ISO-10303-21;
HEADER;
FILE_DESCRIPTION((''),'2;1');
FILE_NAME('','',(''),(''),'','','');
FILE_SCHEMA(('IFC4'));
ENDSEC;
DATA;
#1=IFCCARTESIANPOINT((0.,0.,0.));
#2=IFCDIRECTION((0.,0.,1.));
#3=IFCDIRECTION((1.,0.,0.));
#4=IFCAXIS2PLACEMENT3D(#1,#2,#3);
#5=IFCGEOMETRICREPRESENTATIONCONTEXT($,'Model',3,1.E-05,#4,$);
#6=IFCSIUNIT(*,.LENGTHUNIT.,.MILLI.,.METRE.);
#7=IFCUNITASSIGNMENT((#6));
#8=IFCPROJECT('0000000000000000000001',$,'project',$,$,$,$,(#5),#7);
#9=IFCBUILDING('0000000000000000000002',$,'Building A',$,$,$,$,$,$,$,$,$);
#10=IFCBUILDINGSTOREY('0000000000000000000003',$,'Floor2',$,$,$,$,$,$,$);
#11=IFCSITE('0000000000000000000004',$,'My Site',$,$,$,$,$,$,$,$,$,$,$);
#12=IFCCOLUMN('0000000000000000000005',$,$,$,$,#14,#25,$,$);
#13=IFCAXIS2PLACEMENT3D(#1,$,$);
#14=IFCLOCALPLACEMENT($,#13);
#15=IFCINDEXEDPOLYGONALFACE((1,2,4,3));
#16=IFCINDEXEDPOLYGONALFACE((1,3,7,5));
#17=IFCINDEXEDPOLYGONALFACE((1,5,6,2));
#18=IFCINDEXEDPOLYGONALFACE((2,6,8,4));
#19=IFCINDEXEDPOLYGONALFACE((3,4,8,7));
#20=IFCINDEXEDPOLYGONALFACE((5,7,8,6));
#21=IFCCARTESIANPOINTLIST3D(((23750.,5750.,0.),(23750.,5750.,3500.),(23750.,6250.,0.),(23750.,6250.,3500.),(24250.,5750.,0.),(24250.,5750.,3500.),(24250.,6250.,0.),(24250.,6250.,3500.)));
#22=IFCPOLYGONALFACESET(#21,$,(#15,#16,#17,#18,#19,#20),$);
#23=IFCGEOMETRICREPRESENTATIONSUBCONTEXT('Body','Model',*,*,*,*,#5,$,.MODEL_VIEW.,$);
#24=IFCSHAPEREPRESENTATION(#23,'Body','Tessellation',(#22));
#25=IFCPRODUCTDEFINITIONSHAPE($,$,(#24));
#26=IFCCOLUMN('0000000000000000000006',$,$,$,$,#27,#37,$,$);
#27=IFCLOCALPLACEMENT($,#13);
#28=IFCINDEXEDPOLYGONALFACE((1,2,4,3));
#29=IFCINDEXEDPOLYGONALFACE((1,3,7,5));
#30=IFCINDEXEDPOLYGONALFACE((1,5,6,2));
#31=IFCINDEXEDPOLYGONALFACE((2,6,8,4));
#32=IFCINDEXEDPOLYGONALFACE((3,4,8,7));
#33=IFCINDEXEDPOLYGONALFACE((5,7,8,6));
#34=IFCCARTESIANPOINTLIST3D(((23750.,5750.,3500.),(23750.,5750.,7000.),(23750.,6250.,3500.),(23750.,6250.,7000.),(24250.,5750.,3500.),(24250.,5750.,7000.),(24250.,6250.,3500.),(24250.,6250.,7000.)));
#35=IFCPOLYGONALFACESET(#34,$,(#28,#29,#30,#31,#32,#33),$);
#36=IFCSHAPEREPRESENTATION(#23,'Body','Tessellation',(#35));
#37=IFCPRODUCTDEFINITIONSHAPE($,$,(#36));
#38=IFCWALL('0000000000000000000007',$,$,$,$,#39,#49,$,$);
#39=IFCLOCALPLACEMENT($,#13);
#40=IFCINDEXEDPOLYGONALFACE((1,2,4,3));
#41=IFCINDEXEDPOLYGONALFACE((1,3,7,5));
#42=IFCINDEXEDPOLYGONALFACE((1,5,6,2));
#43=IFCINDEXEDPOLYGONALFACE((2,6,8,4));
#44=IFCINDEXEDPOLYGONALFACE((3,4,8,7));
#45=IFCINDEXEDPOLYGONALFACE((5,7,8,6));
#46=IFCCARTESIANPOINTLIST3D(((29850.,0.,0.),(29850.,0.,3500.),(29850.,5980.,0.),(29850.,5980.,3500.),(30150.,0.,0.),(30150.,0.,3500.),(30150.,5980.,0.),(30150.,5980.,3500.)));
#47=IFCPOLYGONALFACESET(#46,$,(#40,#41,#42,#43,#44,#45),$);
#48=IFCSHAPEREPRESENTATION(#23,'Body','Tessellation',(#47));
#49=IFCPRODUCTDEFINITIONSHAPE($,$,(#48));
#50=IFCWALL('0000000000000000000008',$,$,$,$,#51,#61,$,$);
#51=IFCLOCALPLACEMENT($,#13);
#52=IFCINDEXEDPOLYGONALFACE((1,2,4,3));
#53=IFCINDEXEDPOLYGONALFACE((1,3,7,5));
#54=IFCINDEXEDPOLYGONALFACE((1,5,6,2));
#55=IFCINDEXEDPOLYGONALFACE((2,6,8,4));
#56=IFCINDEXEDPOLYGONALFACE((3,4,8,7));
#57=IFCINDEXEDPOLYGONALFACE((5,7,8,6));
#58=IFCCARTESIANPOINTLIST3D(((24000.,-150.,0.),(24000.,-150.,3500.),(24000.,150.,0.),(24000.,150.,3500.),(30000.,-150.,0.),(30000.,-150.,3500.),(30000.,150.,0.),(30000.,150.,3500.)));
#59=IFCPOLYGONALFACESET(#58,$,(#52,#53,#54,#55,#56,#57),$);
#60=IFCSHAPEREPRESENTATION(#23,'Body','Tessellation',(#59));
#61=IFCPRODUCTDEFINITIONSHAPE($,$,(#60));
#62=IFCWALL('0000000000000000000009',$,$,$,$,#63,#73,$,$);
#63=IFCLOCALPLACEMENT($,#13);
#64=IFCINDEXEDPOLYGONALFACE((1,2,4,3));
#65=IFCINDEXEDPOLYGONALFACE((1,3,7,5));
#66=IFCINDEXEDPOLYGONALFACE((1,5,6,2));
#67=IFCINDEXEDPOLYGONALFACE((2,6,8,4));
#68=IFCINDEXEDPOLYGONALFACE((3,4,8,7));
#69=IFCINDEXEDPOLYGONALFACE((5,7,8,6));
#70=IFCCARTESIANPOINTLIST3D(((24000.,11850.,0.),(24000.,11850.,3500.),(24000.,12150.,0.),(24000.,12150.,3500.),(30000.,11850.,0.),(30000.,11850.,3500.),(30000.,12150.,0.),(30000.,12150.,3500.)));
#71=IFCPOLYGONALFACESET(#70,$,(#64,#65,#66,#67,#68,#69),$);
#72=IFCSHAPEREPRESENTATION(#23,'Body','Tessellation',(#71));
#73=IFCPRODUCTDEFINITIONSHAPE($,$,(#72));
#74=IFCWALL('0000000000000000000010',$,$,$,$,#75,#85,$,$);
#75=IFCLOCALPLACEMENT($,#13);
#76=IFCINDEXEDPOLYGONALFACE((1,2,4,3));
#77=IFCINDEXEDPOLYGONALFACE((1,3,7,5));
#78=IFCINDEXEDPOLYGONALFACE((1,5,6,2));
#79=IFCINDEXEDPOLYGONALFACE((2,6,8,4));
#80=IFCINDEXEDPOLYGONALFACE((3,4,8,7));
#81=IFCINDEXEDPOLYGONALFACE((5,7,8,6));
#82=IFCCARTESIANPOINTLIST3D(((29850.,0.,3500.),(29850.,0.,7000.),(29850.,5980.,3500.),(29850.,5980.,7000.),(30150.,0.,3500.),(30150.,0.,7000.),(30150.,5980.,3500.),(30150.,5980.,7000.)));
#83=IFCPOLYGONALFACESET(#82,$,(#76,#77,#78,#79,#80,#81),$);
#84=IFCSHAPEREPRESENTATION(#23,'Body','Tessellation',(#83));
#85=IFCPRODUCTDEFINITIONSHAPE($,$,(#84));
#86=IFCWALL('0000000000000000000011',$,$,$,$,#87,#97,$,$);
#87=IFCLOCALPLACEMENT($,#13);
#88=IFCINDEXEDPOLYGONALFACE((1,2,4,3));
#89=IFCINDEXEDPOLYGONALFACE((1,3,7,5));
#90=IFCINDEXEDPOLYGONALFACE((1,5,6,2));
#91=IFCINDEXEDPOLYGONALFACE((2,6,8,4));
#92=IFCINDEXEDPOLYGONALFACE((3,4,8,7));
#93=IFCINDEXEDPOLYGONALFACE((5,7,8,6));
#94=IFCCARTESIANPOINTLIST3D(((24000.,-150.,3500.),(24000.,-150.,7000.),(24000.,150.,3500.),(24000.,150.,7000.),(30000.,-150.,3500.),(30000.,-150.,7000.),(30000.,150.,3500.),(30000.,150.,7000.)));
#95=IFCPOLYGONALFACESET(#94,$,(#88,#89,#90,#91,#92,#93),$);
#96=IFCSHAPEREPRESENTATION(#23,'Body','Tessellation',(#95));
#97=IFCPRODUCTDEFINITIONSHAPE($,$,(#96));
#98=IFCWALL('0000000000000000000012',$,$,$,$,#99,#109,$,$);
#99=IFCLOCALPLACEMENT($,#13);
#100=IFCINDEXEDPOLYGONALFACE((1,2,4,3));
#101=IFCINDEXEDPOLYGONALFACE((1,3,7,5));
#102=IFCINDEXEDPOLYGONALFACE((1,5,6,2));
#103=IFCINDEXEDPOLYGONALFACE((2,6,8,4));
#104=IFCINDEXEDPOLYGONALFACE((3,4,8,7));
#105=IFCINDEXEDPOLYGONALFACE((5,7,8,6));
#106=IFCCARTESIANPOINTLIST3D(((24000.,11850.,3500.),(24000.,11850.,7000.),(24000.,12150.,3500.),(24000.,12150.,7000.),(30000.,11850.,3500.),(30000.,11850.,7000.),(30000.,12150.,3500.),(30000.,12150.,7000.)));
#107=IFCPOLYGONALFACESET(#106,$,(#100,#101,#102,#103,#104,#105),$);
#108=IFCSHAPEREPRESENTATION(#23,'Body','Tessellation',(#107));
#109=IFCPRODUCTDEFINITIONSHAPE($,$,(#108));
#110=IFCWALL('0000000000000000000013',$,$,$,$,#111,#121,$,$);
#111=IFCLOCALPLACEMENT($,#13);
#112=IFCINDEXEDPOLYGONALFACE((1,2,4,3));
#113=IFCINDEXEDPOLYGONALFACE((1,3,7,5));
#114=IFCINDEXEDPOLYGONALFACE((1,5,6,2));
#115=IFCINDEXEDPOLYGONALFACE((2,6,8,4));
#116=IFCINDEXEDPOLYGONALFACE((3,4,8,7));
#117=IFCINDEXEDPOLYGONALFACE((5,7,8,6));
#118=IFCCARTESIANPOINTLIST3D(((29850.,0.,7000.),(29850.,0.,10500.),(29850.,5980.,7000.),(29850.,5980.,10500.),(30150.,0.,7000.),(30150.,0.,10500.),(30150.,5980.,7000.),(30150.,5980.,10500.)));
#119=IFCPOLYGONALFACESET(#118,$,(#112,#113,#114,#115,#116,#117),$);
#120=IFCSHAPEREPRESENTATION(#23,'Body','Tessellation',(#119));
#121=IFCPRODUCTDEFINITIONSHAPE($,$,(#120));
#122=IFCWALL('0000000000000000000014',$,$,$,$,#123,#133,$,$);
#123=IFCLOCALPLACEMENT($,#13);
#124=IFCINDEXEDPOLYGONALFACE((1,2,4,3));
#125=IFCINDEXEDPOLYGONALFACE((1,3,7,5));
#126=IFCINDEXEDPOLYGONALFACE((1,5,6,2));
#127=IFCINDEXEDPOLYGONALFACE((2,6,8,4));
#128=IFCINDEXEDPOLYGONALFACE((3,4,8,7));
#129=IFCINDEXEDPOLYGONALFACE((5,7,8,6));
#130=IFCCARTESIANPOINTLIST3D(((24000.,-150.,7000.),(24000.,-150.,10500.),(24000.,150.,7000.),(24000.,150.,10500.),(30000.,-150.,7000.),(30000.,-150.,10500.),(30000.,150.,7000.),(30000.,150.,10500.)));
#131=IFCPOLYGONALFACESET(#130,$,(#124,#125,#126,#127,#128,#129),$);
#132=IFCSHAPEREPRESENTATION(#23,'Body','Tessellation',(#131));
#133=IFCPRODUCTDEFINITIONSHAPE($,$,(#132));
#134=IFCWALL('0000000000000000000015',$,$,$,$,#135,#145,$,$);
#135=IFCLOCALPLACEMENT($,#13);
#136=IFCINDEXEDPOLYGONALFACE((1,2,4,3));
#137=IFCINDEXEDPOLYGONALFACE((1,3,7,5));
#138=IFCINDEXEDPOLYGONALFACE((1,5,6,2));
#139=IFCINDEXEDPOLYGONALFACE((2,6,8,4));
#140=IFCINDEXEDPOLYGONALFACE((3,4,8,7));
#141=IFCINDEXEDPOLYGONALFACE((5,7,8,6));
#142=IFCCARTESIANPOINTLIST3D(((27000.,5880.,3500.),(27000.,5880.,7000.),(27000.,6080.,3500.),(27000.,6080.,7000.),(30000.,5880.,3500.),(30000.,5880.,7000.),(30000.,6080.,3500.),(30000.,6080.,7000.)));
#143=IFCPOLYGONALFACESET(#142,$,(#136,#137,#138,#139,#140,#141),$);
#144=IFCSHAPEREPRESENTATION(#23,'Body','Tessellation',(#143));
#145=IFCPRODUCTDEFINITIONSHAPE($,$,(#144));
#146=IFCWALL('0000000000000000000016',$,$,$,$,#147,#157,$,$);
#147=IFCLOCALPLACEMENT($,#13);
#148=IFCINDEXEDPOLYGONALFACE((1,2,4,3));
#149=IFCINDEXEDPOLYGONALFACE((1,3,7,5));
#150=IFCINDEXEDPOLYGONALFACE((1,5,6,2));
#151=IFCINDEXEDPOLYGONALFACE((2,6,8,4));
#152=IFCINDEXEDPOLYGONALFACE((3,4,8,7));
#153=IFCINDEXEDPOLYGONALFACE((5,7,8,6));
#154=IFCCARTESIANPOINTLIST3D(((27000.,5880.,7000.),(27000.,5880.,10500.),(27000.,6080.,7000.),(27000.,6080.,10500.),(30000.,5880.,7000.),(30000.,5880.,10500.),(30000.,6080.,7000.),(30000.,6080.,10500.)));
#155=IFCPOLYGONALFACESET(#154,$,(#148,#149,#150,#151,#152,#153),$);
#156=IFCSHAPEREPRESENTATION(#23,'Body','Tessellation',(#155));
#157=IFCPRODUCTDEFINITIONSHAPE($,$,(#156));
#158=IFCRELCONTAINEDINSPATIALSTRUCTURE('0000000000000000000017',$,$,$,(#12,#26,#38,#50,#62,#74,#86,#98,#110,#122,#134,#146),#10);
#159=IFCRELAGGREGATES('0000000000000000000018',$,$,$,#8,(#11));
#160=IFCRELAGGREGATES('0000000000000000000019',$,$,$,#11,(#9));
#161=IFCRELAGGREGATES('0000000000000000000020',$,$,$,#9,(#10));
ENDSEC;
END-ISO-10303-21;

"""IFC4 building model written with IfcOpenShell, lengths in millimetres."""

from ifc_helpers import new_model, si_unit, frame, origin_with_axes, place, context, subcontext, project, spatial, line, indexed_curve, outline, extrude, element, save


model = new_model("IFC4")

# Units and contexts
model_context = context("Model", 3, precision=1e-05, world=origin_with_axes())
body_context = subcontext(model_context, "Body", "Model", "MODEL_VIEW")
ifc_project = project(units=[si_unit("LENGTHUNIT", "METRE", prefix="MILLI")], contexts=[model_context])

# Site, building, storey
site = spatial("IfcSite", under=ifc_project, Name="My Site")
building = spatial("IfcBuilding", under=site, Name="Building A")
storey = spatial("IfcBuildingStorey", under=building, Name="Floor2")

# Columns
for number, where, z_axis, x_axis in (
    (1, (24000.0, 6000.0, 0.0), (0.0, 0.0, 1.0), (1.0, 0.0, 0.0)),
    (2, (24000.0, 6000.0, 3500.0), (0.0, 0.0, 1.0), (1.0, 0.0, 0.0)),
):
    element("IfcColumn", number, at=place(None, frame(where, z_axis=z_axis, x_axis=x_axis)), inside=storey, context=body_context, shape_type="SweptSolid", body=[
        extrude(outline(indexed_curve([(-250.0, -250.0), (250.0, -250.0), (250.0, 250.0), (-250.0, 250.0)], segments=[line(1, 2, 3, 4, 1)])), origin_with_axes(), (0.0, 0.0, 1.0), 3500.0),
    ])

# Walls
wall_1_placement = place(None, frame((29850.0, 5980.0, 0.0), z_axis=(0.0, 0.0, 1.0), x_axis=(0.0, -1.0, 0.0)))
element("IfcWall", 3, at=wall_1_placement, inside=storey, context=body_context, shape_type="SweptSolid", body=[
    extrude(outline(indexed_curve([(0.0, 0.0), (0.0, 300.0), (5980.0, 300.0), (5980.0, 0.0), (0.0, 0.0)], self_intersect=False)), origin_with_axes(), (0.0, 0.0, 1.0), 3500.0),
])
for number, where, z_axis, x_axis in (
    (4, (30000.0, 150.0, 0.0), (0.0, 0.0, 1.0), (-1.0, 0.0, 0.0)),
    (5, (24000.0, 11850.0, 0.0), (0.0, 0.0, 1.0), (1.0, 0.0, 0.0)),
):
    element("IfcWall", number, at=place(None, frame(where, z_axis=z_axis, x_axis=x_axis)), inside=storey, context=body_context, shape_type="SweptSolid", body=[
        extrude(outline(indexed_curve([(0.0, 0.0), (0.0, 300.0), (6000.0, 300.0), (6000.0, 0.0), (0.0, 0.0)], self_intersect=False)), origin_with_axes(), (0.0, 0.0, 1.0), 3500.0),
    ])
wall_2_placement = place(None, frame((29850.0, 5980.0, 3500.0), z_axis=(0.0, 0.0, 1.0), x_axis=(0.0, -1.0, 0.0)))
element("IfcWall", 6, at=wall_2_placement, inside=storey, context=body_context, shape_type="SweptSolid", body=[
    extrude(outline(indexed_curve([(0.0, 0.0), (0.0, 300.0), (5980.0, 300.0), (5980.0, 0.0), (0.0, 0.0)], self_intersect=False)), origin_with_axes(), (0.0, 0.0, 1.0), 3500.0),
])
for number, where, z_axis, x_axis in (
    (7, (30000.0, 150.0, 3500.0), (0.0, 0.0, 1.0), (-1.0, 0.0, 0.0)),
    (8, (24000.0, 11850.0, 3500.0), (0.0, 0.0, 1.0), (1.0, 0.0, 0.0)),
):
    element("IfcWall", number, at=place(None, frame(where, z_axis=z_axis, x_axis=x_axis)), inside=storey, context=body_context, shape_type="SweptSolid", body=[
        extrude(outline(indexed_curve([(0.0, 0.0), (0.0, 300.0), (6000.0, 300.0), (6000.0, 0.0), (0.0, 0.0)], self_intersect=False)), origin_with_axes(), (0.0, 0.0, 1.0), 3500.0),
    ])
wall_3_placement = place(None, frame((29850.0, 5980.0, 7000.0), z_axis=(0.0, 0.0, 1.0), x_axis=(0.0, -1.0, 0.0)))
element("IfcWall", 9, at=wall_3_placement, inside=storey, context=body_context, shape_type="SweptSolid", body=[
    extrude(outline(indexed_curve([(0.0, 0.0), (0.0, 300.0), (5980.0, 300.0), (5980.0, 0.0), (0.0, 0.0)], self_intersect=False)), origin_with_axes(), (0.0, 0.0, 1.0), 3500.0),
])
wall_4_placement = place(None, frame((30000.0, 150.0, 7000.0), z_axis=(0.0, 0.0, 1.0), x_axis=(-1.0, 0.0, 0.0)))
element("IfcWall", 10, at=wall_4_placement, inside=storey, context=body_context, shape_type="SweptSolid", body=[
    extrude(outline(indexed_curve([(0.0, 0.0), (0.0, 300.0), (6000.0, 300.0), (6000.0, 0.0), (0.0, 0.0)], self_intersect=False)), origin_with_axes(), (0.0, 0.0, 1.0), 3500.0),
])
for number, where, z_axis, x_axis in (
    (11, (27000.0, 5880.0, 3500.0), (0.0, 0.0, 1.0), (1.0, 0.0, 0.0)),
    (12, (27000.0, 5880.0, 7000.0), (0.0, 0.0, 1.0), (1.0, 0.0, 0.0)),
):
    element("IfcWall", number, at=place(None, frame(where, z_axis=z_axis, x_axis=x_axis)), inside=storey, context=body_context, shape_type="SweptSolid", body=[
        extrude(outline(indexed_curve([(0.0, 0.0), (0.0, 200.0), (3000.0, 200.0), (3000.0, 0.0), (0.0, 0.0)], self_intersect=False)), origin_with_axes(), (0.0, 0.0, 1.0), 3500.0),
    ])

save(model, "model.ifc")
